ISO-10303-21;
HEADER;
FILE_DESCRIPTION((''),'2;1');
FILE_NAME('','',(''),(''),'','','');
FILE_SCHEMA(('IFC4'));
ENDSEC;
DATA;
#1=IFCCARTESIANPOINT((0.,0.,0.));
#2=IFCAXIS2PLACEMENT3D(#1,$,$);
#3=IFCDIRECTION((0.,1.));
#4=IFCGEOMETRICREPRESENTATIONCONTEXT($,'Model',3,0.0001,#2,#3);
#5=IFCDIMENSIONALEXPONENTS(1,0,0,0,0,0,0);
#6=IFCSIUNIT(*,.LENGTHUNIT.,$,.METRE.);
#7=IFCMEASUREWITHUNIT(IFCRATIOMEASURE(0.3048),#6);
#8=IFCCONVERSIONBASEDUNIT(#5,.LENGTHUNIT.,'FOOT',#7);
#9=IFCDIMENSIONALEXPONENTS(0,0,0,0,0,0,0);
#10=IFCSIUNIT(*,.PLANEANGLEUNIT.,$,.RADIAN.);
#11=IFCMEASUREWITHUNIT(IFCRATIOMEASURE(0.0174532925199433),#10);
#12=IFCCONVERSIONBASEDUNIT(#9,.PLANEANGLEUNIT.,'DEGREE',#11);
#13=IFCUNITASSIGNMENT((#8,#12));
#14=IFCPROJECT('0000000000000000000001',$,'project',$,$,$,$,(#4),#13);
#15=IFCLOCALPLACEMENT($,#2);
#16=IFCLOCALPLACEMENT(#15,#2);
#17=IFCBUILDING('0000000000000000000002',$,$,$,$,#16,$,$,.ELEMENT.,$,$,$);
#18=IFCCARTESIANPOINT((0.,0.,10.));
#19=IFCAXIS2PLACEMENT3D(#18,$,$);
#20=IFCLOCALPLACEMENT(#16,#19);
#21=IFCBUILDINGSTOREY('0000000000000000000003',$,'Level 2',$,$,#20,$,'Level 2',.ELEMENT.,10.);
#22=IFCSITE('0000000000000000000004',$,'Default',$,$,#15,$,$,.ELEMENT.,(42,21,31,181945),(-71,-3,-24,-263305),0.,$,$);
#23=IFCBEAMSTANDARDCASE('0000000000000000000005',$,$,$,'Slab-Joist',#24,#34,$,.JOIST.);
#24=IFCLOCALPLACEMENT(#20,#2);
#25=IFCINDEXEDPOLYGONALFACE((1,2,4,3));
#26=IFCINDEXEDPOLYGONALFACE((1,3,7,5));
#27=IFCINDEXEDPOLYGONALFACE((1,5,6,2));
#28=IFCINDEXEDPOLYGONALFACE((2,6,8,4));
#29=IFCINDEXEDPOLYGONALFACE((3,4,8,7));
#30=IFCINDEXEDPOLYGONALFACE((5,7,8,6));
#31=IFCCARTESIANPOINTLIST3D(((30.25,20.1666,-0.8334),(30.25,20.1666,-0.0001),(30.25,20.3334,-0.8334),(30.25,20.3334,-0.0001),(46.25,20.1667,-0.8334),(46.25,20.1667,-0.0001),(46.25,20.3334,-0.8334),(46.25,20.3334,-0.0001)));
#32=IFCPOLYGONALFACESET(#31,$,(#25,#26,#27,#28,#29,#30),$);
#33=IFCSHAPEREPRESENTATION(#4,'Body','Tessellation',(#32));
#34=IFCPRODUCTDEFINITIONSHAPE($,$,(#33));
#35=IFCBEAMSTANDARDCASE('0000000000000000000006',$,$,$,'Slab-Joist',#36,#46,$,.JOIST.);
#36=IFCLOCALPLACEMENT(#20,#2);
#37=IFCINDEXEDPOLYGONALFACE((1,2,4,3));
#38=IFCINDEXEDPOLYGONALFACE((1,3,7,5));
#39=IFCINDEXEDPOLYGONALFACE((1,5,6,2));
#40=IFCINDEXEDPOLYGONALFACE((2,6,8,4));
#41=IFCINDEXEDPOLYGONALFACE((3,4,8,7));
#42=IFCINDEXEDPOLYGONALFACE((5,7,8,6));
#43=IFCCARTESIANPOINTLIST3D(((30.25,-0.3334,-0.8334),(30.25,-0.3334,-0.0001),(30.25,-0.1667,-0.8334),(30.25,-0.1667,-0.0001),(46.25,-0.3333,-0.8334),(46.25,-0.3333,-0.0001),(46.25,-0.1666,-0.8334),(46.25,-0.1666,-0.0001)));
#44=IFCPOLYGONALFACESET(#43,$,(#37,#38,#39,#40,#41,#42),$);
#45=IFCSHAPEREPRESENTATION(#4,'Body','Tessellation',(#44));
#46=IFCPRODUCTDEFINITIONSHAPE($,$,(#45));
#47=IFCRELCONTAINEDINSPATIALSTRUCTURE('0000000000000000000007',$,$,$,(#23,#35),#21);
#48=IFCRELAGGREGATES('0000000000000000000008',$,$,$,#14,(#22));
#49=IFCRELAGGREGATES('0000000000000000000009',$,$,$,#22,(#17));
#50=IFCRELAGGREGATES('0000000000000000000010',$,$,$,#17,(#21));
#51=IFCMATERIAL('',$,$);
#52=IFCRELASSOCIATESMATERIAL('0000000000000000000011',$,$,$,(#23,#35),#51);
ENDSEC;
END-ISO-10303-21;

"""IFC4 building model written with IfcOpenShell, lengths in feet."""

from ifc_helpers import new_model, entity, si_unit, converted_unit, direction, frame, origin, origin_with_axes, place, context, project, spatial, rectangle, extrude, material, element, save


model = new_model("IFC4")

# Units and contexts
model_context = context("Model", 3, precision=0.0001, world=origin(), true_north=direction((0.0, 1.0)))
ifc_project = project(units=[converted_unit("LENGTHUNIT", "FOOT", entity("IfcRatioMeasure", 0.3048), si_unit("LENGTHUNIT", "METRE"), dimensions=[1, 0, 0, 0, 0, 0, 0]), converted_unit("PLANEANGLEUNIT", "DEGREE", entity("IfcRatioMeasure", 0.0174532925199433), si_unit("PLANEANGLEUNIT", "RADIAN"), dimensions=[0, 0, 0, 0, 0, 0, 0])], contexts=[model_context])

# Site, building, storey
site_placement = place(None, origin())
site = spatial("IfcSite", under=ifc_project, at=site_placement, Name="Default", CompositionType="ELEMENT", RefLatitude=(42, 21, 31, 181945), RefLongitude=(-71, -3, -24, -263305), RefElevation=0.0)
building_placement = place(site_placement, origin())
building = spatial("IfcBuilding", under=site, at=building_placement, CompositionType="ELEMENT")
storey_placement = place(building_placement, frame((0.0, 0.0, 10.0)))
storey = spatial("IfcBuildingStorey", under=building, at=storey_placement, Name="Level 2", LongName="Level 2", CompositionType="ELEMENT", Elevation=10.0)

# Beams
ifc_material = material(Name="")
placement_1 = place(storey_placement, frame((30.25, 20.25, 0.0), z_axis=(0.0, 0.0, 1.0), x_axis=(1.0, 0.0, 0.0)))
beam_1_placement = place(placement_1, frame((0.0, 0.0, -0.4167), z_axis=(1.0, 0.0, 0.0), x_axis=(0.0, 1.0, 0.0)))
element("IfcBeamStandardCase", 1, at=beam_1_placement, inside=storey, material=ifc_material, ObjectType="Slab-Joist", PredefinedType="JOIST", context=model_context, shape_type="SweptSolid", body=[
    extrude(rectangle(XDim=0.1667, YDim=0.8333), origin_with_axes(), (0.0, 0.0, 1.0), 16.0),
])
placement_2 = place(storey_placement, frame((30.25, -0.25, 0.0), z_axis=(0.0, 0.0, 1.0), x_axis=(1.0, 0.0, 0.0)))
beam_2_placement = place(placement_2, frame((0.0, 0.0, -0.4167), z_axis=(1.0, 0.0, 0.0), x_axis=(0.0, 1.0, 0.0)))
element("IfcBeamStandardCase", 2, at=beam_2_placement, inside=storey, material=ifc_material, ObjectType="Slab-Joist", PredefinedType="JOIST", context=model_context, shape_type="SweptSolid", body=[
    extrude(rectangle(XDim=0.1667, YDim=0.8333), origin_with_axes(), (0.0, 0.0, 1.0), 16.0),
])

save(model, "model.ifc")
